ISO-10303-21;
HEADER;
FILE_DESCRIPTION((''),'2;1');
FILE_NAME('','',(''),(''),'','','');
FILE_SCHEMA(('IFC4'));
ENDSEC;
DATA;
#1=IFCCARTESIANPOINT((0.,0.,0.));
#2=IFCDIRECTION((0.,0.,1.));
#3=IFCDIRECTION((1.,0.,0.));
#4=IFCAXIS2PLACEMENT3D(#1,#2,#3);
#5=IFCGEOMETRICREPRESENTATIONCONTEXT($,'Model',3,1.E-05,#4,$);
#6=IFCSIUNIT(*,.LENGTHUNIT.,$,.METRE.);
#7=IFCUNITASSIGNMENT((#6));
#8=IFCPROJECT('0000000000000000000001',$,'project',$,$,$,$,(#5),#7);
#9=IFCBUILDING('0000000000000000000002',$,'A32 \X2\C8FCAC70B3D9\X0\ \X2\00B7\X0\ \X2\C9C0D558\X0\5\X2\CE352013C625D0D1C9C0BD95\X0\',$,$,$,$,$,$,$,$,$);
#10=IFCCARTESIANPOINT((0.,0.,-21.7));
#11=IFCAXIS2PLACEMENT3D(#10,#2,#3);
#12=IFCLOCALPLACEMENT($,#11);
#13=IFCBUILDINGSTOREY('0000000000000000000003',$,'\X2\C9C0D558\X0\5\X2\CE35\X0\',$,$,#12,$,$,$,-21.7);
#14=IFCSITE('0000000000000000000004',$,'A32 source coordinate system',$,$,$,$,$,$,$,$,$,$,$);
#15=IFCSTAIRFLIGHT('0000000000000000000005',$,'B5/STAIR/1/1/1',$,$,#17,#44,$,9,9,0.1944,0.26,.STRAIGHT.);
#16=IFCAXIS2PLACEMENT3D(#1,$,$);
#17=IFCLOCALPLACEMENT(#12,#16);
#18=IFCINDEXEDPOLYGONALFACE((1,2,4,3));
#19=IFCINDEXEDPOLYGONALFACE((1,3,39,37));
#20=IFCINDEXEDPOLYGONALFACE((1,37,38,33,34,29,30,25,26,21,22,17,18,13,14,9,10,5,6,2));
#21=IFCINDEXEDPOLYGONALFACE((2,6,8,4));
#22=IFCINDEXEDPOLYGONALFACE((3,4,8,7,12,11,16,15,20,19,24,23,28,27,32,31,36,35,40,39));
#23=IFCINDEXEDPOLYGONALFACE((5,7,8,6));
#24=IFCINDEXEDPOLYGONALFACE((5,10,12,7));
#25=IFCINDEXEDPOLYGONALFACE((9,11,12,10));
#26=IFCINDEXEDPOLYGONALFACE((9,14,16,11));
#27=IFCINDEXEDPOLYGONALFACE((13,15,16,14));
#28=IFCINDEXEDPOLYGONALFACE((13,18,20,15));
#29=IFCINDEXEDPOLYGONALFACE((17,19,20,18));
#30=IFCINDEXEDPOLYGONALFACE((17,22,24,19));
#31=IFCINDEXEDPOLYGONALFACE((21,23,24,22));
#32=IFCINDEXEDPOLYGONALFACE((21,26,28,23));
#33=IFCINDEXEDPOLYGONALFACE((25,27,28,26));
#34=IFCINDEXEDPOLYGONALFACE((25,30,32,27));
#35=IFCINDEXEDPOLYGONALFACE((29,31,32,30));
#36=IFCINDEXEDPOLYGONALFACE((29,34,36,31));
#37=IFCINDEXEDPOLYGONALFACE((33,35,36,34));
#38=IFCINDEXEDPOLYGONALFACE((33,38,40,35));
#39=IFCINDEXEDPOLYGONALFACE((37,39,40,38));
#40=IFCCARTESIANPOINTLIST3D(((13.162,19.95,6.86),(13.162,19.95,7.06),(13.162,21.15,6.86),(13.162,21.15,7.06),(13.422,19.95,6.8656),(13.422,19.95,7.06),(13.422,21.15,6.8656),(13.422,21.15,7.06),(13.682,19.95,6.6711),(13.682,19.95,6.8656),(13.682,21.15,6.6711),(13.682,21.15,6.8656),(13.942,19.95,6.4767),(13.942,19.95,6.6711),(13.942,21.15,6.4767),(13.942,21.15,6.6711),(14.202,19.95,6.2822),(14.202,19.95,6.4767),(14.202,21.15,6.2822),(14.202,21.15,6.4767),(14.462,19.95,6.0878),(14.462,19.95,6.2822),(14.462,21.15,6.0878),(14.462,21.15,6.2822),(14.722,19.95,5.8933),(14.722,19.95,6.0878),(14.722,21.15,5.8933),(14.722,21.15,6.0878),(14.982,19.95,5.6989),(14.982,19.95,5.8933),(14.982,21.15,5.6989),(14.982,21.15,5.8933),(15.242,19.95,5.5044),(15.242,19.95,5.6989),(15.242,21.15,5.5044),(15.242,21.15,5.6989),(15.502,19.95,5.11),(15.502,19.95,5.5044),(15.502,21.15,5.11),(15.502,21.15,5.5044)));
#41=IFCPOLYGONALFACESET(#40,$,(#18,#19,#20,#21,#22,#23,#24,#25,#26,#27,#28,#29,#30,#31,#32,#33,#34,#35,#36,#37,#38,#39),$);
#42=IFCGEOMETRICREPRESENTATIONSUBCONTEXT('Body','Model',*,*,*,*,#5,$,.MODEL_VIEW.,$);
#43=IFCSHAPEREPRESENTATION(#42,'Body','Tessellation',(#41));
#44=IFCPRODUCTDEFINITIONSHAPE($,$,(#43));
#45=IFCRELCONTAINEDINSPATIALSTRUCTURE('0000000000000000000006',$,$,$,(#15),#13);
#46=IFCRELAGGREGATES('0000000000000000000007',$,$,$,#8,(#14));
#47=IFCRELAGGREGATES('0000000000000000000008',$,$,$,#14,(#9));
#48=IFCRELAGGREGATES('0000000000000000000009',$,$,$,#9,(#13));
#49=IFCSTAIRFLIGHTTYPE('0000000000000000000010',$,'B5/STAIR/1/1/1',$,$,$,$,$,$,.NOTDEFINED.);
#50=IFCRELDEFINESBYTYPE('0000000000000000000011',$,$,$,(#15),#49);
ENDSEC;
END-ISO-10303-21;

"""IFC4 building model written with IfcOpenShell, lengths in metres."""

from ifc_helpers import new_model, si_unit, frame, origin, origin_with_axes, place, context, subcontext, project, spatial, polyline, outline, extrude, source, transform, mapped, type_object, type_shapes, element, save


model = new_model("IFC4")

# Units and contexts
model_context = context("Model", 3, precision=1e-05, world=origin_with_axes())
body_context = subcontext(model_context, "Body", "Model", "MODEL_VIEW")
ifc_project = project(units=[si_unit("LENGTHUNIT", "METRE")], contexts=[model_context])

# Site, building, storey
site = spatial("IfcSite", under=ifc_project, Name="A32 source coordinate system")
building = spatial("IfcBuilding", under=site, Name="A32 주거동 · 지하5층–옥탑지붕")
storey_placement = place(None, frame((0.0, 0.0, -21.7), z_axis=(0.0, 0.0, 1.0), x_axis=(1.0, 0.0, 0.0)))
storey = spatial("IfcBuildingStorey", under=building, at=storey_placement, Name="지하5층", Elevation=-21.7)

# Stair flight
stair_flight_type_1 = type_object("IfcStairFlightType", Name="B5/STAIR/1/1/1", PredefinedType="NOTDEFINED")
shared_shape_1 = source(origin(), body_context, "Body", "SweptSolid", [
    extrude(outline(polyline([(0.0, 5.11), (2.34, 6.86), (2.34, 7.06), (2.08, 7.06), (2.08, 6.8656), (1.82, 6.8656), (1.82, 6.6711), (1.56, 6.6711), (1.56, 6.4767), (1.3, 6.4767), (1.3, 6.2822), (1.04, 6.2822), (1.04, 6.0878), (0.78, 6.0878), (0.78, 5.8933), (0.52, 5.8933), (0.52, 5.6989), (0.26, 5.6989), (0.26, 5.5044), (0.0, 5.5044), (0.0, 5.11)])), frame((15.502, 19.95, 0.0), z_axis=(0.0, 1.0, 0.0), x_axis=(-1.0, 0.0, 0.0)), (0.0, 0.0, 1.0), 1.2),
])
type_shapes(stair_flight_type_1, [shared_shape_1])
stair_flight_1_placement = place(storey_placement, origin_with_axes())
element("IfcStairFlight", 1, at=stair_flight_1_placement, inside=storey, type_object=stair_flight_type_1, Name="B5/STAIR/1/1/1", NumberOfRisers=9, NumberOfTreads=9, PredefinedType="STRAIGHT", RiserHeight=0.1944, TreadLength=0.26, context=body_context, shape_type="MappedRepresentation", body=[
    mapped(shared_shape_1, transform((0.0, 0.0, 0.0), scale=1.0)),
])

save(model, "model.ifc")
